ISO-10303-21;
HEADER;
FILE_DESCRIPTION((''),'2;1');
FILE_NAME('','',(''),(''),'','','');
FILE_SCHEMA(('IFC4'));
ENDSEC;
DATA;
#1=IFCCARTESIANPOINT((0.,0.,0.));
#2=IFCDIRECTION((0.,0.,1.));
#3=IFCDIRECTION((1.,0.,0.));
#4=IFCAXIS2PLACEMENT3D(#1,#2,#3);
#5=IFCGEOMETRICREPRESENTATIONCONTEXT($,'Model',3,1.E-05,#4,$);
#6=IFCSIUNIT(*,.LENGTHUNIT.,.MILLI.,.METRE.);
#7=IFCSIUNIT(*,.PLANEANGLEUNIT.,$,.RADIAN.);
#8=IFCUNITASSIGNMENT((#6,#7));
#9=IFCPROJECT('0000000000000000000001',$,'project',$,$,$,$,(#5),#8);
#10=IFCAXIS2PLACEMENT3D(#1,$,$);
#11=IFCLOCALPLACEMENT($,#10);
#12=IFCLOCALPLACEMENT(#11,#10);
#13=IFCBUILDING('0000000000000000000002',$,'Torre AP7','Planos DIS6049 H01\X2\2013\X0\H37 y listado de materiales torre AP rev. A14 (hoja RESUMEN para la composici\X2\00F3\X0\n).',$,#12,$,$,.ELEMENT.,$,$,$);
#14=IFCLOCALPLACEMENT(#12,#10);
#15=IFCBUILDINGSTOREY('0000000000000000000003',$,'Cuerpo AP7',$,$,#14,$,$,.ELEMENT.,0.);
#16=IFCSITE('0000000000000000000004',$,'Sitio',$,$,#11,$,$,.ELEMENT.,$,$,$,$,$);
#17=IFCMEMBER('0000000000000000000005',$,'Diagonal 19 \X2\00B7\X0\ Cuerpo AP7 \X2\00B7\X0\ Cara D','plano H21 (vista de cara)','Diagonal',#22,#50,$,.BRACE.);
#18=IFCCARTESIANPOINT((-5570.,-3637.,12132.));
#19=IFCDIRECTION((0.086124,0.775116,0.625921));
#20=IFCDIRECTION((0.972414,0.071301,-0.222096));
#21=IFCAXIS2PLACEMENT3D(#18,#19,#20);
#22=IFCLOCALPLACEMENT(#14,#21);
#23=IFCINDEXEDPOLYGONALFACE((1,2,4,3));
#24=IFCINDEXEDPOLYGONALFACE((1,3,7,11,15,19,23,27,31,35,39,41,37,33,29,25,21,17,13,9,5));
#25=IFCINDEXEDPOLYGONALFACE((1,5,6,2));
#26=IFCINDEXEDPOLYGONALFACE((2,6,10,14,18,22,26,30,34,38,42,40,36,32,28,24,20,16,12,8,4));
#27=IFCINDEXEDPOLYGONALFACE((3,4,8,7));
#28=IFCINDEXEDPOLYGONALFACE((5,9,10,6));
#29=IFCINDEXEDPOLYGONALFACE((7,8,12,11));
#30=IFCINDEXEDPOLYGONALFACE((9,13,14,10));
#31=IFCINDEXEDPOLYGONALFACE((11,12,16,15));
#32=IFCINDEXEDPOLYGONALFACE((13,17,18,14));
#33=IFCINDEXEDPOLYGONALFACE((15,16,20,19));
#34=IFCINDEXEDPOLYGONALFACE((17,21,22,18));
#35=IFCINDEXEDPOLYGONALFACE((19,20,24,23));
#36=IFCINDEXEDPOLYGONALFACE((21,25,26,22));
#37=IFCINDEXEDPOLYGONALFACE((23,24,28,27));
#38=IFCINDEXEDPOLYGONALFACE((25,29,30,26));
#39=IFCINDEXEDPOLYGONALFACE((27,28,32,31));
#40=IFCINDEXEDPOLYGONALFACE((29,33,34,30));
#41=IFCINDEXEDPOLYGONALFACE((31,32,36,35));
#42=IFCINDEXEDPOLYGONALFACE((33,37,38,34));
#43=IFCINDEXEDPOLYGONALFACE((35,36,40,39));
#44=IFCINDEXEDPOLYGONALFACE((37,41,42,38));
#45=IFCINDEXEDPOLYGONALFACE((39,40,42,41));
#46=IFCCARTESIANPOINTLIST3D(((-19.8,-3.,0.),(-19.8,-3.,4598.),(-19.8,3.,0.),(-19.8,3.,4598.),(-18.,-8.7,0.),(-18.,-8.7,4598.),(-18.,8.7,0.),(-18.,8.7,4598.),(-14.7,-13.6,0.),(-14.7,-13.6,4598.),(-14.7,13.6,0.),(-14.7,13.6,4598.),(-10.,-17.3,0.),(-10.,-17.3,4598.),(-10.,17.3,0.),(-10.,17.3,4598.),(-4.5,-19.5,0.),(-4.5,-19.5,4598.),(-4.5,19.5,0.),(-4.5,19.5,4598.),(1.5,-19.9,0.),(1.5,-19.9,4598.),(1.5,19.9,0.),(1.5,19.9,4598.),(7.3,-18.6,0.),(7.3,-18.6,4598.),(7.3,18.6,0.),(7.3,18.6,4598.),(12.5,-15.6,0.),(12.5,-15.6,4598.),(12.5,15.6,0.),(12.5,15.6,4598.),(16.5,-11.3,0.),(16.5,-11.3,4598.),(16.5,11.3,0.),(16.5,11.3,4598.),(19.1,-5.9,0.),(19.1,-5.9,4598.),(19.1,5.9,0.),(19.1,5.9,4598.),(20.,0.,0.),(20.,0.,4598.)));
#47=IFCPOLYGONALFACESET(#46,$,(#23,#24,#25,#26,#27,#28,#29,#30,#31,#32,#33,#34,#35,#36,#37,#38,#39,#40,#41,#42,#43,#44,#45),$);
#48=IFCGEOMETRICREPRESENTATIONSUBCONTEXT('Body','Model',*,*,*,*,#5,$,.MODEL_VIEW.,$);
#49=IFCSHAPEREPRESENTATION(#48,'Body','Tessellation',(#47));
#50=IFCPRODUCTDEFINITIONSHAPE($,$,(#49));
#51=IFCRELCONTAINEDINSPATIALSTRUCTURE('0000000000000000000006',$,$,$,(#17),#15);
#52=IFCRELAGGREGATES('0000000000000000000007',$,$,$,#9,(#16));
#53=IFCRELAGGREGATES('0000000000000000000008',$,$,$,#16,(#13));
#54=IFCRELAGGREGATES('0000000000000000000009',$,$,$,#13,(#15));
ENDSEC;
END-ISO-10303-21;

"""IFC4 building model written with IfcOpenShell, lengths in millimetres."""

from ifc_helpers import new_model, si_unit, frame, origin, origin_with_axes, place, context, subcontext, project, spatial, circle, extrude, element, save


model = new_model("IFC4")

# Units and contexts
model_context = context("Model", 3, precision=1e-05, world=origin_with_axes())
body_context = subcontext(model_context, "Body", "Model", "MODEL_VIEW")
ifc_project = project(units=[si_unit("LENGTHUNIT", "METRE", prefix="MILLI"), si_unit("PLANEANGLEUNIT", "RADIAN")], contexts=[model_context])

# Site, building, storey
site_placement = place(None, origin())
site = spatial("IfcSite", under=ifc_project, at=site_placement, Name="Sitio", CompositionType="ELEMENT")
building_placement = place(site_placement, origin())
building = spatial("IfcBuilding", under=site, at=building_placement, Name="Torre AP7", Description="Planos DIS6049 H01–H37 y listado de materiales torre AP rev. A14 (hoja RESUMEN para la composición).", CompositionType="ELEMENT")
storey_placement = place(building_placement, origin())
storey = spatial("IfcBuildingStorey", under=building, at=storey_placement, Name="Cuerpo AP7", CompositionType="ELEMENT", Elevation=0.0)

# Member
member_1_placement = place(storey_placement, frame((-5570.0, -3637.0, 12132.0), z_axis=(0.086124, 0.775116, 0.625921), x_axis=(0.972414, 0.071301, -0.222096)))
element("IfcMember", 1, at=member_1_placement, inside=storey, Name="Diagonal 19 · Cuerpo AP7 · Cara D", Description="plano H21 (vista de cara)", ObjectType="Diagonal", PredefinedType="BRACE", context=body_context, shape_type="SweptSolid", body=[
    extrude(circle(Radius=20.0), None, (0.0, 0.0, 1.0), 4598.0),
])

save(model, "model.ifc")
